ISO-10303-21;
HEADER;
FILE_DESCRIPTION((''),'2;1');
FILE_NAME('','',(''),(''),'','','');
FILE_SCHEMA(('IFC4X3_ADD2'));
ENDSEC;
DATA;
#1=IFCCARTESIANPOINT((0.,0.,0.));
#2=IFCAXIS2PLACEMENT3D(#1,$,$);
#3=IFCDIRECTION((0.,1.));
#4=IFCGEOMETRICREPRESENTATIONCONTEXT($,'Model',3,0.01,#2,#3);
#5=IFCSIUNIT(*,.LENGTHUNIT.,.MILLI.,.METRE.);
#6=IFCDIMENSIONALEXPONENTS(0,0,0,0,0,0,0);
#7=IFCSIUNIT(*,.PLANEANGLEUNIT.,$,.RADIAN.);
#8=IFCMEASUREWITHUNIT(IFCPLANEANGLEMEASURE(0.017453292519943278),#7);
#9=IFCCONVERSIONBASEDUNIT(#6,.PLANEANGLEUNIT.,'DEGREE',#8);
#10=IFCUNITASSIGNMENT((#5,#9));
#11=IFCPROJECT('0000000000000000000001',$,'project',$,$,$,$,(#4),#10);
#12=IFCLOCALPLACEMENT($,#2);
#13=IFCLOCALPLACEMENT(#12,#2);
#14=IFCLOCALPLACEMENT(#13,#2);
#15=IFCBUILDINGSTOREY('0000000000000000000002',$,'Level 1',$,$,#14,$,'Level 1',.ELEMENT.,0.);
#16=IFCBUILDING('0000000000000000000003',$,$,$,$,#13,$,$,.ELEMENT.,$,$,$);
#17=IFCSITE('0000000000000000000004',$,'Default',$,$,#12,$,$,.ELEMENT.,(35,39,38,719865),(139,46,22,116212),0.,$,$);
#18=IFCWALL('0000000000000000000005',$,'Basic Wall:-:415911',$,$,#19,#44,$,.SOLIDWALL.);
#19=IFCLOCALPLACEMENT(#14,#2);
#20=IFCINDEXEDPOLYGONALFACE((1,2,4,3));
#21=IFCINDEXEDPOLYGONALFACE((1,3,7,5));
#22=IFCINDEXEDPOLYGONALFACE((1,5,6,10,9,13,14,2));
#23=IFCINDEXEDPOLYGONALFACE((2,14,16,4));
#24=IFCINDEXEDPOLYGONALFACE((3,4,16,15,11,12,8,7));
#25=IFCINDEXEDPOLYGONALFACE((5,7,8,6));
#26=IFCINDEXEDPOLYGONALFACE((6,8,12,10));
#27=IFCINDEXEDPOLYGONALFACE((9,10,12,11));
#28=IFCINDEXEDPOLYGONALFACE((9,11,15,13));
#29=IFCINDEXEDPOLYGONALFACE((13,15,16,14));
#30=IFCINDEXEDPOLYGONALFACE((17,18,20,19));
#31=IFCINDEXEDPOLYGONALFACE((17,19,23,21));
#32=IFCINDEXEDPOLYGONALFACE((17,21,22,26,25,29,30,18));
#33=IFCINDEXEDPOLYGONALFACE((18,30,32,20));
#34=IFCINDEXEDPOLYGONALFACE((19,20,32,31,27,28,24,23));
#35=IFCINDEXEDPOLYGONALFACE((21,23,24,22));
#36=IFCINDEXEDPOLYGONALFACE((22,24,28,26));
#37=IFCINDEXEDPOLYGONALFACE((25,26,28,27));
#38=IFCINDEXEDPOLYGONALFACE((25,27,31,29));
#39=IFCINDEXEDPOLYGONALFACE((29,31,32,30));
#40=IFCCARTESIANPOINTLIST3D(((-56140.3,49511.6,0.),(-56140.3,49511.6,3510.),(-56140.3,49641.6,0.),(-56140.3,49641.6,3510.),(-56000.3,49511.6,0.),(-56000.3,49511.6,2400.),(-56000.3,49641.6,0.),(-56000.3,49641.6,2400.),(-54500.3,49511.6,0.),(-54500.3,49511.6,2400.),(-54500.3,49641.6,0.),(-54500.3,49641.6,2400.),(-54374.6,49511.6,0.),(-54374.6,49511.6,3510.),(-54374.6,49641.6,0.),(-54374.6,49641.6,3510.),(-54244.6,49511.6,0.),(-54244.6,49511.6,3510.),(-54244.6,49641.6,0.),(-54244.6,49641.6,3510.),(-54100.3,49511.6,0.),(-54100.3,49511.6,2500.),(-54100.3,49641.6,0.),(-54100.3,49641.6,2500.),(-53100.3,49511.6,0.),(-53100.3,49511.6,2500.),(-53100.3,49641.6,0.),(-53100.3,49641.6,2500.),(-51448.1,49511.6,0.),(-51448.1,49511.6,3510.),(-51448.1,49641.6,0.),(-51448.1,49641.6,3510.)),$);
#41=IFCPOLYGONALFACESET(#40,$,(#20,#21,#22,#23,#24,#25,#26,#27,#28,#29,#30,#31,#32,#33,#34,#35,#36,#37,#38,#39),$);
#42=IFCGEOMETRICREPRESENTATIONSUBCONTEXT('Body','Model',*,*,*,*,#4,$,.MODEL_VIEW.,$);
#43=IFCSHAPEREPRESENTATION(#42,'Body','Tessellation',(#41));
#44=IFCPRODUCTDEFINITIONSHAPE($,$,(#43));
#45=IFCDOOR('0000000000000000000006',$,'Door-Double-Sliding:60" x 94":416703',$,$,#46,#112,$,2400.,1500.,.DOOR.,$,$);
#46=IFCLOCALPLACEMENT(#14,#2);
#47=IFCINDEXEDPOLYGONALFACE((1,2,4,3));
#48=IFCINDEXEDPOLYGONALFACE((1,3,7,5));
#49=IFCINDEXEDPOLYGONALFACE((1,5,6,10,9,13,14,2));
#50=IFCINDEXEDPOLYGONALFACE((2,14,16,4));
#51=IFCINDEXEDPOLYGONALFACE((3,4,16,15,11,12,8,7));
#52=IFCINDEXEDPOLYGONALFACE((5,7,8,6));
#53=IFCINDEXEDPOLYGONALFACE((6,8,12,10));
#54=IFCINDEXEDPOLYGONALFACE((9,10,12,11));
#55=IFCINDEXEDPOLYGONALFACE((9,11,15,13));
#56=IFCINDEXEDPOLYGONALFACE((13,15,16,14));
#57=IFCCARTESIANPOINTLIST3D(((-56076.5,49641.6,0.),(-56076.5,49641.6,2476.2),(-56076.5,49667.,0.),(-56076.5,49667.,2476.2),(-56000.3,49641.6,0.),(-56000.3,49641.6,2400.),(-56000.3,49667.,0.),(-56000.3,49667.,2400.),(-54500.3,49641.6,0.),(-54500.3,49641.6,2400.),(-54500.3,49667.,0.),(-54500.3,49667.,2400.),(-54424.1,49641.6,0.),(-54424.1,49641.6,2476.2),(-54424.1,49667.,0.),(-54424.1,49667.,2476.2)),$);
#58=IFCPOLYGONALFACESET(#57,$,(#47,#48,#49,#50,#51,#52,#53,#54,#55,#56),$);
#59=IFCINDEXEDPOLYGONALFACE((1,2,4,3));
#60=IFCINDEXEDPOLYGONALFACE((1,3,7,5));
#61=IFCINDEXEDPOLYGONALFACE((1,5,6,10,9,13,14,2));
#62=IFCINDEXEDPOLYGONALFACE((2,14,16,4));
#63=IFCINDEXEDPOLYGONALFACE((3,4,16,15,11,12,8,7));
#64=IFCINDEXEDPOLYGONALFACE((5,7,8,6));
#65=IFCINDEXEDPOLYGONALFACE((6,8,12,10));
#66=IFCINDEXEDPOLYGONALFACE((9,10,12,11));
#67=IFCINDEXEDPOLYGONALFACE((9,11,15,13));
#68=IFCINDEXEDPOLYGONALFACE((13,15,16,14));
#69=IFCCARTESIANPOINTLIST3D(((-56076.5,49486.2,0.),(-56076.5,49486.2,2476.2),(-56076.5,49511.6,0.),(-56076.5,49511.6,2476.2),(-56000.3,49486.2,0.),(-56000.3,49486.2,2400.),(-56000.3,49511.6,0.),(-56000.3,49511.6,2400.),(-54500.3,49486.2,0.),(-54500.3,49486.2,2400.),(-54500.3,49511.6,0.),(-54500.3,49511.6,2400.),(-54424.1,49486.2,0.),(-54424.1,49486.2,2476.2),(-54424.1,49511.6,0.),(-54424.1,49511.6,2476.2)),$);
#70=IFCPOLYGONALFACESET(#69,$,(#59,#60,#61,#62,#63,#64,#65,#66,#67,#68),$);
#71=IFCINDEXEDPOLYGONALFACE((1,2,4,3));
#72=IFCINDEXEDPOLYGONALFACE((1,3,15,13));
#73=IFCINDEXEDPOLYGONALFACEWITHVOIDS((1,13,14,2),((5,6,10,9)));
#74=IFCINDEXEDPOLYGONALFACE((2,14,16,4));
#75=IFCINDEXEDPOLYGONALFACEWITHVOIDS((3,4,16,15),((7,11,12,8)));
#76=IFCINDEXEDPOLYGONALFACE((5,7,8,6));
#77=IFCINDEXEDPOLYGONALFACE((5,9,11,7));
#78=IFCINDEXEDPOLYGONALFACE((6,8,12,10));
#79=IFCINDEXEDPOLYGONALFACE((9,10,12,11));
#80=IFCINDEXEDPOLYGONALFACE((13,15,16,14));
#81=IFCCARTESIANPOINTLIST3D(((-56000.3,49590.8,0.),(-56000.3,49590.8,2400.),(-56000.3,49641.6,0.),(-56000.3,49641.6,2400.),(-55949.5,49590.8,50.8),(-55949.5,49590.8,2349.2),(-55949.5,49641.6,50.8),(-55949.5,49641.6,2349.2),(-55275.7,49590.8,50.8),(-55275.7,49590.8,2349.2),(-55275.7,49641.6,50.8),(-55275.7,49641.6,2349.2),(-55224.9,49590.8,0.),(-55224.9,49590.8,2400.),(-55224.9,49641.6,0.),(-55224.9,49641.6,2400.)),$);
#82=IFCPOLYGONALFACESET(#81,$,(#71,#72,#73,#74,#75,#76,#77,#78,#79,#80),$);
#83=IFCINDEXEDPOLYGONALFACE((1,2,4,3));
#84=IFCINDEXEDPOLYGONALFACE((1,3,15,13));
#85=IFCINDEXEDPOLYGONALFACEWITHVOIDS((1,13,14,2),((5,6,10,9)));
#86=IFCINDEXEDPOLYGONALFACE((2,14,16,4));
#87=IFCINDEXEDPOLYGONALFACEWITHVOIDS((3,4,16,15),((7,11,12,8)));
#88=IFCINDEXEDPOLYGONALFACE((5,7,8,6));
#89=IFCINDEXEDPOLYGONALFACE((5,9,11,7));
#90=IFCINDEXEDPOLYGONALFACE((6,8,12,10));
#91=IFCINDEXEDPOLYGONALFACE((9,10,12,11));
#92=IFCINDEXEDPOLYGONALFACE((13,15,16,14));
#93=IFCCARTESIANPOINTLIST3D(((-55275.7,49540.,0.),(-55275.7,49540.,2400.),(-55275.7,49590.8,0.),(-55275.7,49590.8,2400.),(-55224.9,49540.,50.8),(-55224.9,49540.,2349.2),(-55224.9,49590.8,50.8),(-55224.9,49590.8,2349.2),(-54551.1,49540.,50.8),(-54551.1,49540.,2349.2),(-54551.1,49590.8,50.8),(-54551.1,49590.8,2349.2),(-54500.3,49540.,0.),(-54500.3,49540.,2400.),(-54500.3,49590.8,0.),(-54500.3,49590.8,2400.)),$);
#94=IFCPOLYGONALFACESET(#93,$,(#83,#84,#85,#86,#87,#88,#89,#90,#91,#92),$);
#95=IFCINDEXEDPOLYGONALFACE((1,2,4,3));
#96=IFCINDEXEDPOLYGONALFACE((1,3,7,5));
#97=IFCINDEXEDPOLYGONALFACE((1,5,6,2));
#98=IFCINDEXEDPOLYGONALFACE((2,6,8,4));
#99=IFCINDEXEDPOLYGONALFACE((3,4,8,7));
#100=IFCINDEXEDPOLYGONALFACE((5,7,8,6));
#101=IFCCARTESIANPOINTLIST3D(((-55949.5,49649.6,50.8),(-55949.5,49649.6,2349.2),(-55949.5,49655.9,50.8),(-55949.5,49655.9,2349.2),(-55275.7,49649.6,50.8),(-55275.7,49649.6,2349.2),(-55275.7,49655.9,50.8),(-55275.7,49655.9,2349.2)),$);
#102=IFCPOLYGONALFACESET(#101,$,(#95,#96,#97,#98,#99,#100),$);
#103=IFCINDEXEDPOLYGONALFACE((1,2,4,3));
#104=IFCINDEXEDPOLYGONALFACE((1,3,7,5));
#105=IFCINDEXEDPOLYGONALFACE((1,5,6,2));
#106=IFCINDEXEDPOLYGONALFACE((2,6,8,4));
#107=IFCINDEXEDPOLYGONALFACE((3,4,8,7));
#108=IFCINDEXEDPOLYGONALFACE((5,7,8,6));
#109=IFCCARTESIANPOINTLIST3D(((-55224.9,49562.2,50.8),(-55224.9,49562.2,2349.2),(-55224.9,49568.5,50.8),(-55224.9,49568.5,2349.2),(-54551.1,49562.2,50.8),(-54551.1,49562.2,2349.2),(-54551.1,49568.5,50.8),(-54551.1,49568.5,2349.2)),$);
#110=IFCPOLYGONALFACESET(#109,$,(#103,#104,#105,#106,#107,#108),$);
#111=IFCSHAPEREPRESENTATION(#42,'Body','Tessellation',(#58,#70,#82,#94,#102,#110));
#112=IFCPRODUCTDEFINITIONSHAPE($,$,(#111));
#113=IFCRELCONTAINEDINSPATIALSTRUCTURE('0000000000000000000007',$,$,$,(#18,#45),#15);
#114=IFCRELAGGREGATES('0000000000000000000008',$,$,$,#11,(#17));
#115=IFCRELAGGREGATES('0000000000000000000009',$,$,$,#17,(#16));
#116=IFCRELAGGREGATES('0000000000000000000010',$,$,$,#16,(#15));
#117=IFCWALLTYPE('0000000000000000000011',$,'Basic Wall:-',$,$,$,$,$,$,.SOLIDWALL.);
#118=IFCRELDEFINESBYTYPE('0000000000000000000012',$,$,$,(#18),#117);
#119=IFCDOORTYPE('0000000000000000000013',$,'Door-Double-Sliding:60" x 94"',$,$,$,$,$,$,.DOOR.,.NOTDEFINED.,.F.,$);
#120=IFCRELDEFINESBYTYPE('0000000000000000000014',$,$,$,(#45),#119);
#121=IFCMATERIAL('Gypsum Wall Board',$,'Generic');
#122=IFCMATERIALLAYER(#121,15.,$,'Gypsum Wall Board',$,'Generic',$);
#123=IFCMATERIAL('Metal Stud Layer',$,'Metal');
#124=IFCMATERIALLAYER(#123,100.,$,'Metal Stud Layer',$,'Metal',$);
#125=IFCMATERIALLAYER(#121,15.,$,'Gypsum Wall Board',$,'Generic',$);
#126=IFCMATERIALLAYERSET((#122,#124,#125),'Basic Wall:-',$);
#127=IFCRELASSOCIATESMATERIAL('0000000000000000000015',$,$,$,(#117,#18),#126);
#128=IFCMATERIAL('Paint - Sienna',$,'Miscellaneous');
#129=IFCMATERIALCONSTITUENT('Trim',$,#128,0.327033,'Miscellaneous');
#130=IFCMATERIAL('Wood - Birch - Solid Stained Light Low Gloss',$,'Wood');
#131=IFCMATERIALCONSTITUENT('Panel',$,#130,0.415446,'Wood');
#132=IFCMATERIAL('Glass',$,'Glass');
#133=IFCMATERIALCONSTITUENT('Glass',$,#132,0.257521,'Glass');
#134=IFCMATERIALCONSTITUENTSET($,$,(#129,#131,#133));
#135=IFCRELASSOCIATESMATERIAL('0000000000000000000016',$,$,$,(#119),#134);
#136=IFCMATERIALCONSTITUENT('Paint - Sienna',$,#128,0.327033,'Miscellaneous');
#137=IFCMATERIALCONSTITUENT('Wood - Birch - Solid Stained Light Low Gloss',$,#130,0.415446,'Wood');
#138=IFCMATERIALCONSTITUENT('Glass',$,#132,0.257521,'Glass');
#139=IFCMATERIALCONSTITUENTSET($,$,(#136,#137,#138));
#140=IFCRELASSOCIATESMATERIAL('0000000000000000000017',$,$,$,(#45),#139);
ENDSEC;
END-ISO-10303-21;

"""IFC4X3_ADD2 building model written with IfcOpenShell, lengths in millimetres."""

from ifc_helpers import new_model, entity, si_unit, converted_unit, direction, frame, frame_2d, origin, origin_2d_with_axis, place, context, subcontext, project, spatial, polyline, rectangle, outline, extrude, source, transform, mapped, material, layer, layer_set, constituent, constituent_set, type_object, type_shapes, element, fill, save


model = new_model("IFC4X3_ADD2")

# Units and contexts
model_context = context("Model", 3, precision=0.01, world=origin(), true_north=direction((0.0, 1.0)))
body_context = subcontext(model_context, "Body", "Model", "MODEL_VIEW")
ifc_project = project(units=[si_unit("LENGTHUNIT", "METRE", prefix="MILLI"), converted_unit("PLANEANGLEUNIT", "DEGREE", entity("IfcPlaneAngleMeasure", 0.017453292519943278), si_unit("PLANEANGLEUNIT", "RADIAN"), dimensions=[0, 0, 0, 0, 0, 0, 0])], contexts=[model_context])

# Site, building, storey
site_placement = place(None, origin())
site = spatial("IfcSite", under=ifc_project, at=site_placement, Name="Default", CompositionType="ELEMENT", RefLatitude=(35, 39, 38, 719865), RefLongitude=(139, 46, 22, 116212), RefElevation=0.0)
building_placement = place(site_placement, origin())
building = spatial("IfcBuilding", under=site, at=building_placement, CompositionType="ELEMENT")
storey_placement = place(building_placement, origin())
storey = spatial("IfcBuildingStorey", under=building, at=storey_placement, Name="Level 1", LongName="Level 1", CompositionType="ELEMENT", Elevation=0.0)

# Shared definitions
ifc_material_1 = material(Name="Glass", Category="Glass")

# Wall, openings, door
ifc_material_2 = material(Name="Gypsum Wall Board", Category="Generic")
ifc_layer_1 = layer(ifc_material_2, 15.0, Name="Gypsum Wall Board", Category="Generic")
ifc_material_3 = material(Name="Metal Stud Layer", Category="Metal")
ifc_layer_2 = layer(ifc_material_3, 100.0, Name="Metal Stud Layer", Category="Metal")
ifc_layer_3 = layer(ifc_material_2, 15.0, Name="Gypsum Wall Board", Category="Generic")
ifc_layer_set_1 = layer_set([ifc_layer_1, ifc_layer_2, ifc_layer_3], Name="Basic Wall:-")
wall_type = type_object("IfcWallType", Name="Basic Wall:-", PredefinedType="SOLIDWALL", material=ifc_layer_set_1)
wall_1_placement = place(storey_placement, frame((-51448.1, 49576.6, 0.0), z_axis=(0.0, 0.0, 1.0), x_axis=(-1.0, 0.0, 0.0)))
wall_1 = element("IfcWall", 1, at=wall_1_placement, inside=storey, type_object=wall_type, material=ifc_layer_set_1, Name="Basic Wall:-:415911", PredefinedType="SOLIDWALL", context=body_context, shape_type="SweptSolid", body=[
    extrude(rectangle(XDim=4692.1, YDim=130.0, at=frame_2d((2346.1, 0.0), x_axis=(-1.0, 0.0))), origin(), (0.0, 0.0, 1.0), 3510.0),
])
opening_1_placement = place(storey_placement, frame((-51448.1, 49576.6, 0.0), z_axis=(0.0, 0.0, 1.0), x_axis=(-1.0, 0.0, 0.0)))
element("IfcOpeningElement", 2, at=opening_1_placement, cuts=wall_1, PredefinedType="OPENING", context=body_context, shape_type="SweptSolid", body=[
    extrude(rectangle(XDim=3510.0, YDim=130.0, at=frame_2d((0.0, 0.0), x_axis=(1.0, 0.0))), frame((2926.4, 0.0, 1755.0), z_axis=(-1.0, 0.0, 0.0), x_axis=(0.0, 0.0, 1.0)), (0.0, 0.0, 1.0), 130.0),
])
opening_2_placement = place(wall_1_placement, frame((4552.1, 65.0, 0.0)))
opening_2 = element("IfcOpeningElement", 3, at=opening_2_placement, cuts=wall_1, PredefinedType="OPENING", context=body_context, shape_type="SweptSolid", body=[
    extrude(rectangle(XDim=2400.0, YDim=1500.0, at=frame_2d((1200.0, 750.0), x_axis=(-1.0, 0.0))), frame((0.0, 0.0, 0.0), z_axis=(0.0, -1.0, 0.0), x_axis=(0.0, 0.0, 1.0)), (0.0, 0.0, 1.0), 130.0),
])
opening_3_placement = place(wall_1_placement, frame((2652.1, 65.0, 0.0)))
element("IfcOpeningElement", 4, at=opening_3_placement, cuts=wall_1, PredefinedType="OPENING", context=body_context, shape_type="SweptSolid", body=[
    extrude(rectangle(XDim=2500.0, YDim=1000.0, at=frame_2d((1250.0, 500.0), x_axis=(1.0, 0.0))), frame((0.0, 0.0, 0.0), z_axis=(0.0, -1.0, 0.0), x_axis=(0.0, 0.0, 1.0)), (0.0, 0.0, 1.0), 130.0),
])
ifc_material_4 = material(Name="Paint - Sienna", Category="Miscellaneous")
ifc_constituent_1 = constituent(ifc_material_4, Name="Paint - Sienna", Category="Miscellaneous", fraction=0.327033)
ifc_material_5 = material(Name="Wood - Birch - Solid Stained Light Low Gloss", Category="Wood")
ifc_constituent_2 = constituent(ifc_material_5, Name="Wood - Birch - Solid Stained Light Low Gloss", Category="Wood", fraction=0.415446)
ifc_constituent_3 = constituent(ifc_material_1, Name="Glass", Category="Glass", fraction=0.257521)
ifc_constituent_set_1 = constituent_set(constituents=[ifc_constituent_1, ifc_constituent_2, ifc_constituent_3])
ifc_constituent_4 = constituent(ifc_material_4, Name="Trim", Category="Miscellaneous", fraction=0.327033)
ifc_constituent_5 = constituent(ifc_material_5, Name="Panel", Category="Wood", fraction=0.415446)
ifc_constituent_6 = constituent(ifc_material_1, Name="Glass", Category="Glass", fraction=0.257521)
ifc_constituent_set_2 = constituent_set(constituents=[ifc_constituent_4, ifc_constituent_5, ifc_constituent_6])
door_type_1 = type_object("IfcDoorType", Name="Door-Double-Sliding:60\" x 94\"", OperationType="NOTDEFINED", ParameterTakesPrecedence=False, PredefinedType="DOOR", material=ifc_constituent_set_2)
shared_shape_1 = source(origin(), body_context, "Body", "SweptSolid", [
    extrude(outline(polyline([(-826.2, -1219.0), (-750.0, -1219.0), (-750.0, 1181.0), (750.0, 1180.9), (750.0, -1219.1), (826.2, -1219.1), (826.2, 1257.1), (-826.2, 1257.1), (-826.2, -1219.0)])), frame((750.0, 130.0, 1219.0), z_axis=(0.0, 1.0, 0.0), x_axis=(-1.0, 0.0, 0.0)), (0.0, 0.0, 1.0), 25.4),
    extrude(outline(polyline([(-1219.0, -826.2), (1257.1, -826.2), (1257.1, 826.2), (-1219.0, 826.2), (-1219.0, 750.0), (1180.9, 750.0), (1180.9, -750.0), (-1219.0, -750.0), (-1219.0, -826.2)])), frame((750.0, -25.4, 1219.0), z_axis=(0.0, 1.0, 0.0), x_axis=(0.0, 0.0, 1.0)), (0.0, 0.0, 1.0), 25.4),
    extrude(outline(polyline([(-1200.0, -387.7), (1200.0, -387.7), (1200.0, 387.7), (-1200.0, 387.7), (-1200.0, -387.7)]), holes=[polyline([(-1149.2, -336.9), (-1149.2, 336.9), (1149.2, 336.9), (1149.2, -336.9), (-1149.2, -336.9)])]), frame((387.7, 79.2, 1200.0), z_axis=(0.0, 1.0, 0.0), x_axis=(0.0, 0.0, -1.0)), (0.0, 0.0, 1.0), 50.8),
    extrude(outline(polyline([(-387.7, -1200.0), (387.7, -1200.0), (387.7, 1200.0), (-387.7, 1200.0), (-387.7, -1200.0)]), holes=[polyline([(-336.9, -1149.2), (-336.9, 1149.2), (336.9, 1149.2), (336.9, -1149.2), (-336.9, -1149.2)])]), frame((1112.3, 28.4, 1200.0), z_axis=(0.0, 1.0, 0.0), x_axis=(1.0, 0.0, 0.0)), (0.0, 0.0, 1.0), 50.8),
    extrude(rectangle(XDim=6.4, YDim=673.8, at=origin_2d_with_axis()), frame((387.7, 141.2, 50.8), z_axis=(0.0, 0.0, 1.0), x_axis=(0.0, 1.0, 0.0)), (0.0, 0.0, 1.0), 2298.4),
    extrude(rectangle(XDim=6.3, YDim=673.8, at=frame_2d((0.0, 0.0), x_axis=(1.0, 0.0))), frame((1112.3, 53.8, 50.8), z_axis=(0.0, 0.0, 1.0), x_axis=(0.0, -1.0, 0.0)), (0.0, 0.0, 1.0), 2298.4),
])
type_shapes(door_type_1, [shared_shape_1])
door_1_placement = place(opening_2_placement, frame((0.0, 0.0, 0.0), z_axis=(0.0, 0.0, 1.0), x_axis=(-1.0, 0.0, 0.0)))
door_1 = element("IfcDoor", 5, at=door_1_placement, inside=storey, type_object=door_type_1, material=ifc_constituent_set_1, Name="Door-Double-Sliding:60\" x 94\":416703", OverallHeight=2400.0, OverallWidth=1500.0, PredefinedType="DOOR", context=body_context, shape_type="MappedRepresentation", body=[
    mapped(shared_shape_1, transform((0.0, 0.0, 0.0), scale=1.0)),
])
fill(opening_2, door_1)

save(model, "model.ifc")
